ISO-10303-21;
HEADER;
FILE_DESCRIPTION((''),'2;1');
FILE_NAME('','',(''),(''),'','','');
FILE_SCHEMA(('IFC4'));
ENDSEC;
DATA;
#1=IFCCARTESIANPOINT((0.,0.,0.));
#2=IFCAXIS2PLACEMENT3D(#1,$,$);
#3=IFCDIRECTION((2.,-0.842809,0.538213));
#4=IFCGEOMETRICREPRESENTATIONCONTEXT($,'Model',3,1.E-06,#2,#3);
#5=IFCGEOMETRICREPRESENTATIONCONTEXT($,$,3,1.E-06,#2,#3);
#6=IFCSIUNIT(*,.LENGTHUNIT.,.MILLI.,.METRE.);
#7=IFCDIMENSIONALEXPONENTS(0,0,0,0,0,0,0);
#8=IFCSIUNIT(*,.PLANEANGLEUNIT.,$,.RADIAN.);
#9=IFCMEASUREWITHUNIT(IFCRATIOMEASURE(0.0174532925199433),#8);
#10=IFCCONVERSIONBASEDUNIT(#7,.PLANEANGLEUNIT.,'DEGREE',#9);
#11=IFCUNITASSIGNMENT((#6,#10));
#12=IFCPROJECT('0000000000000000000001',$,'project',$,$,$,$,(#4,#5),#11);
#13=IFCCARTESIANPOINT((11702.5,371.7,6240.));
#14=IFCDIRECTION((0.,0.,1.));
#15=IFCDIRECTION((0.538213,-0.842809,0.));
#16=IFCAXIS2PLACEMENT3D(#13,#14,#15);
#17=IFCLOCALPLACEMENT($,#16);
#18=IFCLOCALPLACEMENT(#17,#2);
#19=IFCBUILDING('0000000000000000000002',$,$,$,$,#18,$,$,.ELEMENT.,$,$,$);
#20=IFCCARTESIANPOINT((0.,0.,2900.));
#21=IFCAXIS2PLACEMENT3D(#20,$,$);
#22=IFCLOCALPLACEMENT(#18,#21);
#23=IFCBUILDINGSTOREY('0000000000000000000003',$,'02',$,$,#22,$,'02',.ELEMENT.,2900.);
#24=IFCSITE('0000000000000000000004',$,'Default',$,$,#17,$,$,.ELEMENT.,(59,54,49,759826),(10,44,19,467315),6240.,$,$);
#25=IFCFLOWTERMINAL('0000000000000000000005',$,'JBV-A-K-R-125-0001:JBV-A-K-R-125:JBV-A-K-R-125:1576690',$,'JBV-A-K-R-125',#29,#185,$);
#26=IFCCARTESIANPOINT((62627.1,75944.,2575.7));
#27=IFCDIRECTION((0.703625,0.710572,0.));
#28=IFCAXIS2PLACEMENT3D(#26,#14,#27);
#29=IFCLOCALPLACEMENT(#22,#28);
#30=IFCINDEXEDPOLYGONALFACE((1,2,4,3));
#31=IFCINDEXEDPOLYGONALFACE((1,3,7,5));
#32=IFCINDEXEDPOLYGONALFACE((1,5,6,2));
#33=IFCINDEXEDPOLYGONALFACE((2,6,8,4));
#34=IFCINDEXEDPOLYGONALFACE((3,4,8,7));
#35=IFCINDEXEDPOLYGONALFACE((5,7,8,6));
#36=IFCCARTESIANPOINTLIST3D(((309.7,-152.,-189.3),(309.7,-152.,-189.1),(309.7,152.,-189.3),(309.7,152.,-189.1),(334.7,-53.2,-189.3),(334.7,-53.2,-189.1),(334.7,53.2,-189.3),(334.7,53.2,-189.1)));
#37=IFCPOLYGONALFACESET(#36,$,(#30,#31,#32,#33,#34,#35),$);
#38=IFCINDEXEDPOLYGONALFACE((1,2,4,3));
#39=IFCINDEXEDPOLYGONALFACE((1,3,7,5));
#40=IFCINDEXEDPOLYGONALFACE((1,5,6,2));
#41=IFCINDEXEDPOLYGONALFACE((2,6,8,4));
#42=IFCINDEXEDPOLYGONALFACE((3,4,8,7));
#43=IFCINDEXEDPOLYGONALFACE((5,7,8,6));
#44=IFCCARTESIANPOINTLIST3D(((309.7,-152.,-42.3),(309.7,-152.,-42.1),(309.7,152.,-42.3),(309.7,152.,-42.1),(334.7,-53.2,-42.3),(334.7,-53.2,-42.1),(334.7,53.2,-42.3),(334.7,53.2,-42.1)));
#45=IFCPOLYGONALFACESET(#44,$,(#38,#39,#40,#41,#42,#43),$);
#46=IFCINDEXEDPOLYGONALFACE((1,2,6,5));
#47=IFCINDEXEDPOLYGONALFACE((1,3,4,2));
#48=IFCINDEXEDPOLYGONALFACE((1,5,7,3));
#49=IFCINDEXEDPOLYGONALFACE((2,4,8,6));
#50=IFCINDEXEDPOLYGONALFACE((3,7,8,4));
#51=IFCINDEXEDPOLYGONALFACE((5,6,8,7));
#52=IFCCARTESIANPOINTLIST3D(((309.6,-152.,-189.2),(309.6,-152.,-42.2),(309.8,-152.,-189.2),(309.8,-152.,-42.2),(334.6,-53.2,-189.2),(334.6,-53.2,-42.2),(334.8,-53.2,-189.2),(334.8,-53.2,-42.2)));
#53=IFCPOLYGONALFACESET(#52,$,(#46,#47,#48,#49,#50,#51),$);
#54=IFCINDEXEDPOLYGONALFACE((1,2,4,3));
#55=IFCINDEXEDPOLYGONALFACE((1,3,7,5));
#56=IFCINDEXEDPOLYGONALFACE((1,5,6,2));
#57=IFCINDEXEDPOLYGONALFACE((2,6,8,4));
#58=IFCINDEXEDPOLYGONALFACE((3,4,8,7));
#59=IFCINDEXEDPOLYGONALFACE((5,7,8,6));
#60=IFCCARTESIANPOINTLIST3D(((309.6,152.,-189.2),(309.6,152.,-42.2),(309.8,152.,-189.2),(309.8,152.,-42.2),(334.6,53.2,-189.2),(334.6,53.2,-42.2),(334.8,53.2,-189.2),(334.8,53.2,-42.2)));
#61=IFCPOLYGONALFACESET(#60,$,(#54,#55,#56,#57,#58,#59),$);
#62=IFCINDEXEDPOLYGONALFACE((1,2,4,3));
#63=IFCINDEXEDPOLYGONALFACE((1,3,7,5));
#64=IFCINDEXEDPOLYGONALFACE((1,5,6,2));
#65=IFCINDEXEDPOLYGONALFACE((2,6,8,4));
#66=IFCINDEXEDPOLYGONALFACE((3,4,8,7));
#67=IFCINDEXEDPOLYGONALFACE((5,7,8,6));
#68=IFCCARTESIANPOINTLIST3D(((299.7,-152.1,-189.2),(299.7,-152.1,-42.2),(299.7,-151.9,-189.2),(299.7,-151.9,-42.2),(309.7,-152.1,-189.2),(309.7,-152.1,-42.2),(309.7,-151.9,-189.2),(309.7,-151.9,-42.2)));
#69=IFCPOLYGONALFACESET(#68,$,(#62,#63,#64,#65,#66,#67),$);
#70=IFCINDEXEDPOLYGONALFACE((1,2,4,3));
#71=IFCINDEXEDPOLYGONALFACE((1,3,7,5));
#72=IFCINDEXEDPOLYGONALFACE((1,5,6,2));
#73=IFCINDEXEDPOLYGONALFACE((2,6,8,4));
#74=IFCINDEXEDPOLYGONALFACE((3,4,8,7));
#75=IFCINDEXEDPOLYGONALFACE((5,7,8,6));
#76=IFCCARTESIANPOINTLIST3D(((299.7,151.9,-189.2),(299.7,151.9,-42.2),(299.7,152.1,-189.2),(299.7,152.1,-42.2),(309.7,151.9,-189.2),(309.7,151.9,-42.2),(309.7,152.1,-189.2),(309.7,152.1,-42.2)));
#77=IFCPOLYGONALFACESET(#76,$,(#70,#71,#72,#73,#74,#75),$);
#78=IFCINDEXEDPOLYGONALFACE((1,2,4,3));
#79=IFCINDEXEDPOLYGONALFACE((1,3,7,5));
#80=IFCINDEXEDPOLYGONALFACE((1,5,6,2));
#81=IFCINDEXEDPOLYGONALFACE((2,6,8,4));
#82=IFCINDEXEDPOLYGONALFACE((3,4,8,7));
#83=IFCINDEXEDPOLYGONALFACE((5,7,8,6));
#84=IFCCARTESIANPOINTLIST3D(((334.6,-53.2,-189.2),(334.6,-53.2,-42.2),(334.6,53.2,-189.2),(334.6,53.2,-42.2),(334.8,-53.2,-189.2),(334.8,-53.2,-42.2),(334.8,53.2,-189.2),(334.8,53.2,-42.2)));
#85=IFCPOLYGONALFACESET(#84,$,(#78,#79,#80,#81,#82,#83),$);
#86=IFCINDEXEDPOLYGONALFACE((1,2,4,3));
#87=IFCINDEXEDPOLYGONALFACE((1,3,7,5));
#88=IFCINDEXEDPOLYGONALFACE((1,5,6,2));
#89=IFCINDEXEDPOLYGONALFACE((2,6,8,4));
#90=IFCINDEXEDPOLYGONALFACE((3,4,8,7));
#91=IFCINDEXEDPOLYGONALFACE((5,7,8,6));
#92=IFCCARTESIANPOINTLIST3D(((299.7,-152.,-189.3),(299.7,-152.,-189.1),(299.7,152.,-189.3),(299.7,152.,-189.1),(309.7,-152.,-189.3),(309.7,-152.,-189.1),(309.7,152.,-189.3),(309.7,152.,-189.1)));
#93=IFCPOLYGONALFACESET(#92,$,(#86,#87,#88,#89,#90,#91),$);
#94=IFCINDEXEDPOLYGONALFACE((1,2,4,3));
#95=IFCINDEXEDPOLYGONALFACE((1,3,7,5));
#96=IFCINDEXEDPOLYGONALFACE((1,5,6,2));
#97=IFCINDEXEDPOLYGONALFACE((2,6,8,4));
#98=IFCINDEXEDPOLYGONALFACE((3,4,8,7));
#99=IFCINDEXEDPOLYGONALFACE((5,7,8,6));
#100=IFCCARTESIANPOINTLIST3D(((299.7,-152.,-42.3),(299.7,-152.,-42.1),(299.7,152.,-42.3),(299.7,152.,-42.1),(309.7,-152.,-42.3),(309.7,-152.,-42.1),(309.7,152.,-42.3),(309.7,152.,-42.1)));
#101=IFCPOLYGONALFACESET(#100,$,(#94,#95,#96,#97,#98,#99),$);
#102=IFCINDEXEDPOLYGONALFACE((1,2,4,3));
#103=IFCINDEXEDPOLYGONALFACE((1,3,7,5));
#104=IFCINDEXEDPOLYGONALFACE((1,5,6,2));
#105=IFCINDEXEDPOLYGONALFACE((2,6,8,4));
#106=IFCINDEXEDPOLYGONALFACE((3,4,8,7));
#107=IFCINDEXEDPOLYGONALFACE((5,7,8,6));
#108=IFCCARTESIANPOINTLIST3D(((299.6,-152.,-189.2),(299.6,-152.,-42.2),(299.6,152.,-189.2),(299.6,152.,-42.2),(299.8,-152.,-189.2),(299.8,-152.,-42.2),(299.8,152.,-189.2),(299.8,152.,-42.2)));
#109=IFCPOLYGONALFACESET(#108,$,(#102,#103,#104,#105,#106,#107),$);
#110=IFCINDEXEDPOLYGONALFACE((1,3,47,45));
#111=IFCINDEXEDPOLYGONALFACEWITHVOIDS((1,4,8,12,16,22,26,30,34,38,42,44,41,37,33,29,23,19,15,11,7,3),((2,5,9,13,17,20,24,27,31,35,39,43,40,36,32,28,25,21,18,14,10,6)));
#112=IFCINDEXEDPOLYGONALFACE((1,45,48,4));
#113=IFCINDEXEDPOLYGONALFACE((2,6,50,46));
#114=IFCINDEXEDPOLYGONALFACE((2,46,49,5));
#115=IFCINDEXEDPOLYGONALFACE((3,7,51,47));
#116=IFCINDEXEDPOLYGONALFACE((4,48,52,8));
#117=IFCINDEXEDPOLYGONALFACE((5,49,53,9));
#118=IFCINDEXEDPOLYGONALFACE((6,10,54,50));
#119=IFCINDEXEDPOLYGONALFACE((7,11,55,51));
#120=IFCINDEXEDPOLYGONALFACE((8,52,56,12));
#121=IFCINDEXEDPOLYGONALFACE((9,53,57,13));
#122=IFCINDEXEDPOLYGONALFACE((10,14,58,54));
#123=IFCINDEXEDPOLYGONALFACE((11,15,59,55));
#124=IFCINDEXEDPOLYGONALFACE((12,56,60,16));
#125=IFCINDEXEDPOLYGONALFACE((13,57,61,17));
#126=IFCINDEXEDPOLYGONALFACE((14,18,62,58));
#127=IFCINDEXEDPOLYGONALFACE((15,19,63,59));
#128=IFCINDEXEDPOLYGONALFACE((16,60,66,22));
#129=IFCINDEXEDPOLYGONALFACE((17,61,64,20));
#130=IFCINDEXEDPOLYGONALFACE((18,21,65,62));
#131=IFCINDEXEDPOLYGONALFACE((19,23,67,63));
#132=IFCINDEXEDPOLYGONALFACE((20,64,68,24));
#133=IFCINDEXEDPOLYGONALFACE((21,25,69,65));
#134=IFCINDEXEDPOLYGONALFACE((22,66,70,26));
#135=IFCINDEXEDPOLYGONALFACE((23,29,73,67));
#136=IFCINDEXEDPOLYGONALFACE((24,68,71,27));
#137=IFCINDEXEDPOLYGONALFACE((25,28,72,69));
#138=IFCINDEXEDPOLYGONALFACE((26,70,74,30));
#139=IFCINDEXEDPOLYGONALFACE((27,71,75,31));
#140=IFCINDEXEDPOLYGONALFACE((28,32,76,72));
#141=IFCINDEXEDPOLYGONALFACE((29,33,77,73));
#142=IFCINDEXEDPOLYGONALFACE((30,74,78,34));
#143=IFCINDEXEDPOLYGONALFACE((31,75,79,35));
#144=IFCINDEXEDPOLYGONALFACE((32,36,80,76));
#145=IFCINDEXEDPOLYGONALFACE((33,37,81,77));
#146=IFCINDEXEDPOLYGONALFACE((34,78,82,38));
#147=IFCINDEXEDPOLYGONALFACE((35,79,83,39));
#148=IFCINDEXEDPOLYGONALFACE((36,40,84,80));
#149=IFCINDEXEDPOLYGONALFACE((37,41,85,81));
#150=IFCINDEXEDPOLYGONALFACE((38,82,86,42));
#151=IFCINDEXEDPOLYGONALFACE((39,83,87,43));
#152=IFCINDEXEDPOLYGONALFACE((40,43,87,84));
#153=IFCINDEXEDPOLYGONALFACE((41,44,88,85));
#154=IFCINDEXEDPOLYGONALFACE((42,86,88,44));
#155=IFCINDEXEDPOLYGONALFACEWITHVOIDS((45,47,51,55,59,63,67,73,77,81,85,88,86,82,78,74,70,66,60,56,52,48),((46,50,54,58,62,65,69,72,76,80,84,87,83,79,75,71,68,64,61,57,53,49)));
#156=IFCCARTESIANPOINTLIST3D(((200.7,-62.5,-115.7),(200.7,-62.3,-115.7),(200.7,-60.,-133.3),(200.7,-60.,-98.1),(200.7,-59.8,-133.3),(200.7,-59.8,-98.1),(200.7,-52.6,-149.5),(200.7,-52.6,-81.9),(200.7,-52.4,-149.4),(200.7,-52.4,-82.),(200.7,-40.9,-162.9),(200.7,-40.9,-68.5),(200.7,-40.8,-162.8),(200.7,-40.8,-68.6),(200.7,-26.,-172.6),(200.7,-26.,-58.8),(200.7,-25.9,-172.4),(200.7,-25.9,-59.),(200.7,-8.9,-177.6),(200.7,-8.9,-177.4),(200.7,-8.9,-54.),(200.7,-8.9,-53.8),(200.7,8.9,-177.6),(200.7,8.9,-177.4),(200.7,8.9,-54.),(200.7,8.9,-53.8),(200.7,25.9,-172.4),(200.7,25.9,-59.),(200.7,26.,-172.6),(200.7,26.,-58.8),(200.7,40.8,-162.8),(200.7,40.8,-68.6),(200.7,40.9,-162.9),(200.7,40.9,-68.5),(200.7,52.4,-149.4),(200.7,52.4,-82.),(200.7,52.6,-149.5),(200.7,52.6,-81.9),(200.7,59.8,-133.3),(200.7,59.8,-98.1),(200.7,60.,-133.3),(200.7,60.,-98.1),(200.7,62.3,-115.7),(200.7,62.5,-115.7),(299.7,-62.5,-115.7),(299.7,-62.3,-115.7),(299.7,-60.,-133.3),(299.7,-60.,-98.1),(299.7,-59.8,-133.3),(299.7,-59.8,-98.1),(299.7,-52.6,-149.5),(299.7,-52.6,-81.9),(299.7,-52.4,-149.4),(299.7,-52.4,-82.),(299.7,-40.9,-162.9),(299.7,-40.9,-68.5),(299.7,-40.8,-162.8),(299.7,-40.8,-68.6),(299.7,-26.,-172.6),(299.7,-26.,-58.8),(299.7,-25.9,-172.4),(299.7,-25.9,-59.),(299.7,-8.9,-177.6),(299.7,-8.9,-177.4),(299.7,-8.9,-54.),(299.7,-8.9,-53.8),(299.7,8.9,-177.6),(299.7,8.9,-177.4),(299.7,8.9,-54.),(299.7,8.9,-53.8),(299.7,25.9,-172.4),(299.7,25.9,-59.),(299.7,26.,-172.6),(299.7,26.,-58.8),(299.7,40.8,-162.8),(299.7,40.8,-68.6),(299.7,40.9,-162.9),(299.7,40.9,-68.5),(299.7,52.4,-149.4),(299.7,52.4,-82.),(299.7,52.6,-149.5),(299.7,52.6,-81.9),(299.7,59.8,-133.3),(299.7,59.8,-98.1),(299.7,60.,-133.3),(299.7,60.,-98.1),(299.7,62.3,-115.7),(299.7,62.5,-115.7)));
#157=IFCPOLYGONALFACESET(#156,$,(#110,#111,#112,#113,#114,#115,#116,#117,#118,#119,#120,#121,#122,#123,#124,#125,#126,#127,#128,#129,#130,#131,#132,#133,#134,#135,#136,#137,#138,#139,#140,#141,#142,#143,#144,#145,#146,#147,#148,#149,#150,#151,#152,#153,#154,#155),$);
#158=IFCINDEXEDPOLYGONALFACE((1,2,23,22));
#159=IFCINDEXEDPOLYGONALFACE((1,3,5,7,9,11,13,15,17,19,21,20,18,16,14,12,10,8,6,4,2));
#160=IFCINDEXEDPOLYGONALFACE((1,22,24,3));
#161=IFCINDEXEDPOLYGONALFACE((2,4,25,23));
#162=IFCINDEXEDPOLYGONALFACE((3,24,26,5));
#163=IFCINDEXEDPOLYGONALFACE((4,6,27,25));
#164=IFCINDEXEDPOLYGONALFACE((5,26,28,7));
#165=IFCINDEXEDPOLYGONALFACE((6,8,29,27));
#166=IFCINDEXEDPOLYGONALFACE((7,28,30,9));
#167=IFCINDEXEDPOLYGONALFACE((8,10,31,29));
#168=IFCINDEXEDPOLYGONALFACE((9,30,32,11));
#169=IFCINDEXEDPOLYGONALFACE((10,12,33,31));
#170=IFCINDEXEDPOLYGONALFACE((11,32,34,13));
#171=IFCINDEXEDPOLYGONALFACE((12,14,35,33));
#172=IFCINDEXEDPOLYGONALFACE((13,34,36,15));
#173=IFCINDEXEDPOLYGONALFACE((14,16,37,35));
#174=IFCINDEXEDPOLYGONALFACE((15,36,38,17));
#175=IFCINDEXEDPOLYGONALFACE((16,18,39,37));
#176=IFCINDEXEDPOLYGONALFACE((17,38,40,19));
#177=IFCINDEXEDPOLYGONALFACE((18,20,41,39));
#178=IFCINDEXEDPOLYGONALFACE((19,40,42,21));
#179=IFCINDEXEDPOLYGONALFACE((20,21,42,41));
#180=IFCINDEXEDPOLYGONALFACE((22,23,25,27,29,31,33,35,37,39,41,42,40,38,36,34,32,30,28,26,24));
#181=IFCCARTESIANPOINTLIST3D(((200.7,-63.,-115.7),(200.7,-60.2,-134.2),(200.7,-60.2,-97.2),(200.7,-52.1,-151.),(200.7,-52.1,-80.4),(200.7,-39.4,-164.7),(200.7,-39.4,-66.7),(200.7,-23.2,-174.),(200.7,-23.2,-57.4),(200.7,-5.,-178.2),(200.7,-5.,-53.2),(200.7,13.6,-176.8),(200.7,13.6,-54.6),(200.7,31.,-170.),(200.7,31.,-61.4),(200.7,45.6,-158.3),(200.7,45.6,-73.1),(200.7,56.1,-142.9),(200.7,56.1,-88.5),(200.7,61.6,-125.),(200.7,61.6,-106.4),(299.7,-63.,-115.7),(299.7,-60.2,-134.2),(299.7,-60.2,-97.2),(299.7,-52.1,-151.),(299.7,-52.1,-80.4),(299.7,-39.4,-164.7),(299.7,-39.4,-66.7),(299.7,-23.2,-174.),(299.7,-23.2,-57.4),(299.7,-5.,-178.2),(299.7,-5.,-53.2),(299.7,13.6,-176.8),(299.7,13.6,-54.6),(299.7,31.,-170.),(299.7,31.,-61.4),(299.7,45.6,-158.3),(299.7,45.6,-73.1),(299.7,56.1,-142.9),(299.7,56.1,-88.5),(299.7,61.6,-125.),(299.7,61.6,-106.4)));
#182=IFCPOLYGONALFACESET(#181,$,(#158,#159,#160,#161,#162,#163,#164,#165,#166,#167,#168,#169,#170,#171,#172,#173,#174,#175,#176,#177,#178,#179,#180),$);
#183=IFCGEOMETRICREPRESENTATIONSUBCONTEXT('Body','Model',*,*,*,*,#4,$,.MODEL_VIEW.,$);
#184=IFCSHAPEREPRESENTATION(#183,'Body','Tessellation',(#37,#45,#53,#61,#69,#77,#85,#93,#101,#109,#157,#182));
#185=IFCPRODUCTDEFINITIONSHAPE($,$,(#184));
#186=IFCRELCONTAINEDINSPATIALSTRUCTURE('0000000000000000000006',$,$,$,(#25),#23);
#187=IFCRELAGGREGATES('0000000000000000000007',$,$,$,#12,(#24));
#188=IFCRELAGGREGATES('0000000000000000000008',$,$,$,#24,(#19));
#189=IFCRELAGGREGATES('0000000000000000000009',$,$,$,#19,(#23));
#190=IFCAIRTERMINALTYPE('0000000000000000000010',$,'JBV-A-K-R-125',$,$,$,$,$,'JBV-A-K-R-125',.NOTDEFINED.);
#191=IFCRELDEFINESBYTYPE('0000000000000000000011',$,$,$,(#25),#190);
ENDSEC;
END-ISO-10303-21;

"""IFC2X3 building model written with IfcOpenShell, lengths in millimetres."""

from ifc_helpers import new_model, entity, si_unit, converted_unit, direction, frame, frame_2d, origin, origin_2d_with_axis, place, context, subcontext, project, spatial, polyline, circle_curve, parameter, trimmed, segment, composite_curve, rectangle, circle, outline, extrude, source, transform, mapped, type_object, type_shapes, element, save


model = new_model("IFC2X3")

# Units and contexts
model_context = context("Model", 3, precision=1e-06, world=origin(), true_north=direction((2.0, -0.842809, 0.538213)))
context_of_model = context(None, 3, precision=1e-06, world=origin(), true_north=direction((2.0, -0.842809, 0.538213)))
body_context = subcontext(model_context, "Body", "Model", "MODEL_VIEW")
ifc_project = project(units=[si_unit("LENGTHUNIT", "METRE", prefix="MILLI"), converted_unit("PLANEANGLEUNIT", "DEGREE", entity("IfcRatioMeasure", 0.0174532925199433), si_unit("PLANEANGLEUNIT", "RADIAN"), dimensions=[0, 0, 0, 0, 0, 0, 0])], contexts=[model_context, context_of_model])

# Site, building, storey
site_placement = place(None, frame((11702.5, 371.7, 6240.0), z_axis=(0.0, 0.0, 1.0), x_axis=(0.538213, -0.842809, 0.0)))
site = spatial("IfcSite", under=ifc_project, at=site_placement, Name="Default", CompositionType="ELEMENT", RefLatitude=(59, 54, 49, 759826), RefLongitude=(10, 44, 19, 467315), RefElevation=6240.0)
building_placement = place(site_placement, origin())
building = spatial("IfcBuilding", under=site, at=building_placement, CompositionType="ELEMENT")
storey_placement = place(building_placement, frame((0.0, 0.0, 2900.0)))
storey = spatial("IfcBuildingStorey", under=building, at=storey_placement, Name="02", LongName="02", CompositionType="ELEMENT", Elevation=2900.0)

# Flow terminal
air_terminal_type_1 = type_object("IfcAirTerminalType", Name="JBV-A-K-R-125", ElementType="JBV-A-K-R-125", PredefinedType="NOTDEFINED")
shared_shape_1 = source(origin(), body_context, "Body", "SweptSolid", [
    extrude(outline(polyline([(-150.4, -25.2), (-48.5, -25.2), (54.6, 0.9), (144.3, 49.4), (-150.4, -25.2)])), frame((322.2, 0.0, -189.3), z_axis=(0.0, 0.0, 1.0), x_axis=(0.245305, 0.969446, 0.0)), (0.0, 0.0, 1.0), 0.2),
    extrude(outline(polyline([(-150.4, -25.2), (-48.5, -25.2), (54.6, 0.9), (144.3, 49.4), (-150.4, -25.2)])), frame((322.2, 0.0, -42.3), z_axis=(0.0, 0.0, 1.0), x_axis=(0.245305, 0.969446, 0.0)), (0.0, 0.0, 1.0), 0.2),
    extrude(rectangle(XDim=101.9, YDim=0.2, at=frame_2d((0.0, 0.0), x_axis=(1.0, 0.0))), frame((322.2, -102.6, -189.2), z_axis=(0.0, 0.0, 1.0), x_axis=(-0.245305, -0.969446, 0.0)), (0.0, 0.0, 1.0), 147.0),
    extrude(rectangle(XDim=101.9, YDim=0.2, at=frame_2d((0.0, 0.0), x_axis=(1.0, 0.0))), frame((322.2, 102.6, -189.2), z_axis=(0.0, 0.0, 1.0), x_axis=(-0.245305, 0.969446, 0.0)), (0.0, 0.0, 1.0), 147.0),
    extrude(rectangle(XDim=10.0, YDim=0.2, at=frame_2d((0.0, 0.0), x_axis=(1.0, 0.0))), frame((304.7, -152.0, -189.2), z_axis=(0.0, 0.0, 1.0), x_axis=(-1.0, 0.0, 0.0)), (0.0, 0.0, 1.0), 147.0),
    extrude(rectangle(XDim=10.0, YDim=0.2, at=frame_2d((0.0, 0.0), x_axis=(1.0, 0.0))), frame((304.7, 152.0, -189.2), z_axis=(0.0, 0.0, 1.0), x_axis=(-1.0, 0.0, 0.0)), (0.0, 0.0, 1.0), 147.0),
    extrude(rectangle(XDim=106.4, YDim=0.2, at=frame_2d((0.0, 0.0), x_axis=(1.0, 0.0))), frame((334.7, 0.0, -189.2), z_axis=(0.0, 0.0, 1.0), x_axis=(0.0, -1.0, 0.0)), (0.0, 0.0, 1.0), 147.0),
    extrude(rectangle(XDim=10.0, YDim=304.0, at=frame_2d((0.0, 0.0), x_axis=(1.0, 0.0))), frame((304.7, 0.0, -189.3)), (0.0, 0.0, 1.0), 0.2),
    extrude(rectangle(XDim=10.0, YDim=304.0, at=frame_2d((0.0, 0.0), x_axis=(1.0, 0.0))), frame((304.7, 0.0, -42.3)), (0.0, 0.0, 1.0), 0.2),
    extrude(rectangle(XDim=304.0, YDim=0.2, at=frame_2d((0.0, 0.0), x_axis=(1.0, 0.0))), frame((299.7, 0.0, -189.2), z_axis=(0.0, 0.0, 1.0), x_axis=(0.0, -1.0, 0.0)), (0.0, 0.0, 1.0), 147.0),
    extrude(outline(composite_curve([segment(trimmed(circle_curve(origin_2d_with_axis(), 62.5), [parameter(0.0)], [parameter(180.0)], True, "PARAMETER"), True, "CONTINUOUS"), segment(trimmed(circle_curve(origin_2d_with_axis(), 62.5), [parameter(180.0)], [parameter(0.0)], True, "PARAMETER"), True, "CONTINUOUS")], self_intersect=False), holes=[composite_curve([segment(trimmed(circle_curve(origin_2d_with_axis(), 62.3), [parameter(180.0)], [parameter(360.0)], True, "PARAMETER"), False, "CONTINUOUS"), segment(trimmed(circle_curve(origin_2d_with_axis(), 62.3), [parameter(0.0)], [parameter(180.0)], True, "PARAMETER"), False, "CONTINUOUS")], self_intersect=False)]), frame((200.7, 0.0, -115.7), z_axis=(1.0, 0.0, 0.0), x_axis=(0.0, -1.0, 0.0)), (0.0, 0.0, 1.0), 99.0),
    extrude(circle(Radius=62.6, at=frame_2d((0.0, 0.0), x_axis=(1.0, 0.0))), frame((200.7, -0.3, -115.7), z_axis=(1.0, 0.0, 0.0), x_axis=(0.0, -1.0, 0.0)), (0.0, 0.0, 1.0), 99.0),
])
type_shapes(air_terminal_type_1, [shared_shape_1])
for number, where, z_axis, x_axis, name in (
    (1, (62627.1, 75944.0, 2575.7), (0.0, 0.0, 1.0), (0.703625, 0.710572, 0.0), "JBV-A-K-R-125-0001:JBV-A-K-R-125:JBV-A-K-R-125:1576690"),
):
    element("IfcFlowTerminal", number, at=place(storey_placement, frame(where, z_axis=z_axis, x_axis=x_axis)), inside=storey, type_object=air_terminal_type_1, Name=name, ObjectType="JBV-A-K-R-125", context=body_context, shape_type="MappedRepresentation", body=[
        mapped(shared_shape_1, transform((0.0, 0.0, 0.0), scale=1.0)),
    ])

save(model, "model.ifc")
